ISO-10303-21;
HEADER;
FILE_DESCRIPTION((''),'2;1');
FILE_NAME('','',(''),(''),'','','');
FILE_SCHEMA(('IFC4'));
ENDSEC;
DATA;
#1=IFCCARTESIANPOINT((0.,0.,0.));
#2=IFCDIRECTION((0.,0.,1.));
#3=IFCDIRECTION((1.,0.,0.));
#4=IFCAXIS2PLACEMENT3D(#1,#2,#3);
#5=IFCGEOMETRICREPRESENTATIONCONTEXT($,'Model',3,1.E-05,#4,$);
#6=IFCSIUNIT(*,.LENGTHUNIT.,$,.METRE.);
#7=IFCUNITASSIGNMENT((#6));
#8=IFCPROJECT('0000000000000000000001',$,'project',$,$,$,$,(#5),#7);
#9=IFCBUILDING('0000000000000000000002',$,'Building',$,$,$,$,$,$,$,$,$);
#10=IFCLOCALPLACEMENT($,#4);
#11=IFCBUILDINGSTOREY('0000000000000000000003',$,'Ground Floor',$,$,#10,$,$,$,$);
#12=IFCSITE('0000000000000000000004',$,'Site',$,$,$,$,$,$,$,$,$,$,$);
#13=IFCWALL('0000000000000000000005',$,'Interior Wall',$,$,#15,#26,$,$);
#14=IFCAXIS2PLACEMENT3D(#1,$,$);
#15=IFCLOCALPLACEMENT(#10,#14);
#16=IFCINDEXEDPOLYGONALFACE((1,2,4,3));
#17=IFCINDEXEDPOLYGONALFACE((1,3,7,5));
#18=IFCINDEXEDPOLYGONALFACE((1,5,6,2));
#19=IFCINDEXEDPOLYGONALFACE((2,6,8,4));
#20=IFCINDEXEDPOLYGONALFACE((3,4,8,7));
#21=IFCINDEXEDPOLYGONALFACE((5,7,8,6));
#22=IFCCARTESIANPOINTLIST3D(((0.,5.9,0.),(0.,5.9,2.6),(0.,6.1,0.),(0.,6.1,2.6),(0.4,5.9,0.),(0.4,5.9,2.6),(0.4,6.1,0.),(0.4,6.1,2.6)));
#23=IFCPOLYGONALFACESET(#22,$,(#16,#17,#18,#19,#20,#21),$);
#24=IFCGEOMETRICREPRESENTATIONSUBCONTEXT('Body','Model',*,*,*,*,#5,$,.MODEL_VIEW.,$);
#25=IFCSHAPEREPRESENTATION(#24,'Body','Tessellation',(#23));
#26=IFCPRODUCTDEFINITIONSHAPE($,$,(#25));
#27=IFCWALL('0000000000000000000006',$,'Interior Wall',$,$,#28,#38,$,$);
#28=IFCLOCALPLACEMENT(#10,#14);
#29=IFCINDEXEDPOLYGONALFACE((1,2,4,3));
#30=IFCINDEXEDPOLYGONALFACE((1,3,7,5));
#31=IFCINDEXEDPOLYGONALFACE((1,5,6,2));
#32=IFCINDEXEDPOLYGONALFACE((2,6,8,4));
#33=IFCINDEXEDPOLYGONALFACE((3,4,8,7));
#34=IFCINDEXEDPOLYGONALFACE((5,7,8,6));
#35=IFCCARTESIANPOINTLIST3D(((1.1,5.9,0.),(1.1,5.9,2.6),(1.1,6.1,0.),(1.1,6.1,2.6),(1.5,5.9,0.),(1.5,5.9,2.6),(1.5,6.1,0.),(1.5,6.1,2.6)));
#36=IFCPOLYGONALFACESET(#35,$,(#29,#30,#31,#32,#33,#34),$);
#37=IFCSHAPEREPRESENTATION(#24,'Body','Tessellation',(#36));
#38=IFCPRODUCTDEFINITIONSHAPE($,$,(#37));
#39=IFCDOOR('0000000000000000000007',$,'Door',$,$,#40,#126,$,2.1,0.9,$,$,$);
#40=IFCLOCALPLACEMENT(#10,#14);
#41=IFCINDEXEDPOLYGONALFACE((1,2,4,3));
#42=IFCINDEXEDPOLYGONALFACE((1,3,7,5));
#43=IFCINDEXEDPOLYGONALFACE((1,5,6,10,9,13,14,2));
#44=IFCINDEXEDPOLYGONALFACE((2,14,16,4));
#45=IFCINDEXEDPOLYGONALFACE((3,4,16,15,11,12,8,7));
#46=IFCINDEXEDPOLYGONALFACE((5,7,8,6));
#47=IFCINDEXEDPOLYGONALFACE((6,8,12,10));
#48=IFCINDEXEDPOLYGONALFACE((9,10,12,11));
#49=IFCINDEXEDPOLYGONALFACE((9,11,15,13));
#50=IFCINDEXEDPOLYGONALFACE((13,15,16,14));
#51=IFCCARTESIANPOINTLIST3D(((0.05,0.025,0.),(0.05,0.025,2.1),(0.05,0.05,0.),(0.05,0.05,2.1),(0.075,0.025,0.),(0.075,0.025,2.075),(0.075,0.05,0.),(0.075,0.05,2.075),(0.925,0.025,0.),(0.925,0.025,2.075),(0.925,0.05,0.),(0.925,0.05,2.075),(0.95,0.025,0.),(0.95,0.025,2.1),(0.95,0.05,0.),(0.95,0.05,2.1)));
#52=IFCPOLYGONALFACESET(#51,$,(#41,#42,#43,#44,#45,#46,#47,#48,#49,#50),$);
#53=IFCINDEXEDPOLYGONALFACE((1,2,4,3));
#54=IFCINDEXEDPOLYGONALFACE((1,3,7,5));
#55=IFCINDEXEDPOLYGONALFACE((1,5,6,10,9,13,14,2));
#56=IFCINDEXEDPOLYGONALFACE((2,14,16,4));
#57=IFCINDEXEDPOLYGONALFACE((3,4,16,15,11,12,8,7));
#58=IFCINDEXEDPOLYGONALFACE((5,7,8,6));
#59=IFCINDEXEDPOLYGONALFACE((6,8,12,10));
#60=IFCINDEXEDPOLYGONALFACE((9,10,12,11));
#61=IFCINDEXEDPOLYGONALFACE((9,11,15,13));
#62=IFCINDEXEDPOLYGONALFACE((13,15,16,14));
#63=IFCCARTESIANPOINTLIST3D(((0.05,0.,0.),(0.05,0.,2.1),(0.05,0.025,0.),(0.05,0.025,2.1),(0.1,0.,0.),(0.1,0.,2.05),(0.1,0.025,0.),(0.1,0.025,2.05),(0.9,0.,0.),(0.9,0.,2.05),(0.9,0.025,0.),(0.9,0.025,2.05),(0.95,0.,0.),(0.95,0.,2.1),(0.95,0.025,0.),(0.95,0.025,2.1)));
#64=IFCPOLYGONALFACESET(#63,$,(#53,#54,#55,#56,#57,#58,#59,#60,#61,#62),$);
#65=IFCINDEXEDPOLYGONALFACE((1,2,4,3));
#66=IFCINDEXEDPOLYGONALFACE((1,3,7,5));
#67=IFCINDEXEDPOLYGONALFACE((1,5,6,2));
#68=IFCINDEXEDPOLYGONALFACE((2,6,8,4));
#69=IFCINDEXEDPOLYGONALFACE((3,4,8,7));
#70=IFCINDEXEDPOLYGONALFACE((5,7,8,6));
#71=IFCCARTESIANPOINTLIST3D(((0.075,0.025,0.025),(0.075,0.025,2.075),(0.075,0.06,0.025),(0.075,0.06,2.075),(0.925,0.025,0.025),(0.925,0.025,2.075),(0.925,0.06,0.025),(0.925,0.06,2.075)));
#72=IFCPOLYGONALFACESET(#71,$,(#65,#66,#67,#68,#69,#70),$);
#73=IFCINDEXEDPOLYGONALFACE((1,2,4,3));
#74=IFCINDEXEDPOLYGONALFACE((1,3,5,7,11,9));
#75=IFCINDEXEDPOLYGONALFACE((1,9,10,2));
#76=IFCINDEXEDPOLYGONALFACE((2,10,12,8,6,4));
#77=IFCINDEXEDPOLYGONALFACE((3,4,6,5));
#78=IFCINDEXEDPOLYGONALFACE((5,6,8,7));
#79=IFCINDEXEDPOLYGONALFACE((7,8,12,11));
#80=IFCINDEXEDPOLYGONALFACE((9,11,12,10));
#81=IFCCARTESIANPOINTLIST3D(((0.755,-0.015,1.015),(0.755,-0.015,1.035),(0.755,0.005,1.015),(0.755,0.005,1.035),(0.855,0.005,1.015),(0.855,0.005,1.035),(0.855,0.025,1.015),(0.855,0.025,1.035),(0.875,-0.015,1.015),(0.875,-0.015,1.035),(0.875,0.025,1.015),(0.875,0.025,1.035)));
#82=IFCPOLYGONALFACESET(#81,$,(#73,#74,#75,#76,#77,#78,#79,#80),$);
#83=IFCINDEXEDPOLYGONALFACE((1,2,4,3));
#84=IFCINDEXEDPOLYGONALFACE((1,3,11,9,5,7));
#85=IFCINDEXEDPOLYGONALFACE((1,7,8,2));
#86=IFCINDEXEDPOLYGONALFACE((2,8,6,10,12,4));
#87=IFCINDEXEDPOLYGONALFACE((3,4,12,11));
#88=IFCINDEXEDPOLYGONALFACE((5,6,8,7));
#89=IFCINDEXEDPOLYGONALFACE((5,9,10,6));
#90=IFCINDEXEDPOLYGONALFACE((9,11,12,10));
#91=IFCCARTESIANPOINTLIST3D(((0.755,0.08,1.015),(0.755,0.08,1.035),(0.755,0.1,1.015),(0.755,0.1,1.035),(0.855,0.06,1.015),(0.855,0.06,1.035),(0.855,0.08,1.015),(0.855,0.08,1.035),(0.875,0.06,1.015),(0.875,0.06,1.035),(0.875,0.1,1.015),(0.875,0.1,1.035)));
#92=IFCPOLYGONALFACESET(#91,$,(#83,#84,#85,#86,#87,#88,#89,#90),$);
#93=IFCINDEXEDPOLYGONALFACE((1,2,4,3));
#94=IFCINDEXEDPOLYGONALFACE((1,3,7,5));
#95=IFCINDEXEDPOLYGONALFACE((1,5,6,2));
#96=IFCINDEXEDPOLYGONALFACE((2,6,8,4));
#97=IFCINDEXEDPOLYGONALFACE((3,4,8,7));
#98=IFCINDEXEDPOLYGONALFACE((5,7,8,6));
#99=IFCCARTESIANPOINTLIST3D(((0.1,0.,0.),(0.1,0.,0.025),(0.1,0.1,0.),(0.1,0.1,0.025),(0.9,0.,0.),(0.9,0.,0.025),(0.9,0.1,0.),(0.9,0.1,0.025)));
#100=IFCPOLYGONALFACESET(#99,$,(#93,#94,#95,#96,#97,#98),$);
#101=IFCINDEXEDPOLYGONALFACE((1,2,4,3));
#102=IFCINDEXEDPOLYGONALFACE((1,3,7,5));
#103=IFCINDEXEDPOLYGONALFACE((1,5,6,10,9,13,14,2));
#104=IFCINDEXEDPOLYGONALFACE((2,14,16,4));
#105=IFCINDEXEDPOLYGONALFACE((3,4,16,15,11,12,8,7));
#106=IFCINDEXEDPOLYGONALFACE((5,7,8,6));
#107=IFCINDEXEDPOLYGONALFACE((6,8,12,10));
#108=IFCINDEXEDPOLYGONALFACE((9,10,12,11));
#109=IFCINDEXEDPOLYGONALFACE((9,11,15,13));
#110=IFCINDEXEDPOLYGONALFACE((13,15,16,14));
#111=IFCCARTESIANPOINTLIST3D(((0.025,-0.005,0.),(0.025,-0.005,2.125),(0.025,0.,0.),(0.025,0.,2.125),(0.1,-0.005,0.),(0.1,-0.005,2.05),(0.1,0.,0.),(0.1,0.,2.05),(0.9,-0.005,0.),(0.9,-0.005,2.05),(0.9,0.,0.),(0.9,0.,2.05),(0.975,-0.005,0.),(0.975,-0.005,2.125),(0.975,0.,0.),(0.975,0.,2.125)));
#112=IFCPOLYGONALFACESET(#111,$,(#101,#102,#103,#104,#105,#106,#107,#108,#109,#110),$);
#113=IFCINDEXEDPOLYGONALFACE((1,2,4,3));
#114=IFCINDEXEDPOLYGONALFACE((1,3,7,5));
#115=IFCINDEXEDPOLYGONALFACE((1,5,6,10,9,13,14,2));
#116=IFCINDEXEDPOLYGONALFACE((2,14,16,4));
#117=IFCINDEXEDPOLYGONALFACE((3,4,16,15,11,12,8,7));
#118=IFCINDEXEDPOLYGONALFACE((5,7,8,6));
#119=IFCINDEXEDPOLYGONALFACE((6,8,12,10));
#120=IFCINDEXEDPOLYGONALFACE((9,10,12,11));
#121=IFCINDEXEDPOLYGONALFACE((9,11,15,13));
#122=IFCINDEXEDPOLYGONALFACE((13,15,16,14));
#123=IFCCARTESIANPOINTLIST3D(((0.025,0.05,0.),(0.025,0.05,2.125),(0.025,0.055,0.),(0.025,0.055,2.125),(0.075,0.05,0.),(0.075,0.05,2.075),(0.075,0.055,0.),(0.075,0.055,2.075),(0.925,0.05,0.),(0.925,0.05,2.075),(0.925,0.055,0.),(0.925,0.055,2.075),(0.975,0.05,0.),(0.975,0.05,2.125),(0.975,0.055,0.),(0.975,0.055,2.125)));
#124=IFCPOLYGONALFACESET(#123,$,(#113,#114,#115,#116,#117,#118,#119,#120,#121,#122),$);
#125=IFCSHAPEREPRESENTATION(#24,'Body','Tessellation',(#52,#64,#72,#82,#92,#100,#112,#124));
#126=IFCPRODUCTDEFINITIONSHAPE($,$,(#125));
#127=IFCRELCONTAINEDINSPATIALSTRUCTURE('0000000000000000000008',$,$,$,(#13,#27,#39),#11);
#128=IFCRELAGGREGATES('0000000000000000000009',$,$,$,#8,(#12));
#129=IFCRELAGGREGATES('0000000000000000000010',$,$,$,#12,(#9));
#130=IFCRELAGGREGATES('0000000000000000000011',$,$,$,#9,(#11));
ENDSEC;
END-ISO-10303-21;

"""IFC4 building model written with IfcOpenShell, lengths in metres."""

from ifc_helpers import new_model, si_unit, frame, origin_with_axes, place, context, subcontext, project, spatial, line, indexed_curve, outline, extrude, element, save


model = new_model("IFC4")

# Units and contexts
model_context = context("Model", 3, precision=1e-05, world=origin_with_axes())
body_context = subcontext(model_context, "Body", "Model", "MODEL_VIEW")
ifc_project = project(units=[si_unit("LENGTHUNIT", "METRE")], contexts=[model_context])

# Site, building, storey
site = spatial("IfcSite", under=ifc_project, Name="Site")
building = spatial("IfcBuilding", under=site, Name="Building")
storey_placement = place(None, origin_with_axes())
storey = spatial("IfcBuildingStorey", under=building, at=storey_placement, Name="Ground Floor")

# Walls
wall_1_placement = place(storey_placement, frame((0.0, 6.0, 0.0), z_axis=(0.0, 0.0, 1.0), x_axis=(1.0, 0.0, 0.0)))
element("IfcWall", 1, at=wall_1_placement, inside=storey, Name="Interior Wall", context=body_context, shape_type="SweptSolid", body=[
    extrude(outline(indexed_curve([(0.0, 0.0), (0.0, 0.2), (0.4, 0.2), (0.4, 0.0), (0.0, 0.0)], self_intersect=False)), frame((0.0, -0.1, 0.0), z_axis=(0.0, 0.0, 1.0), x_axis=(1.0, 0.0, 0.0)), (0.0, 0.0, 1.0), 2.6),
])
wall_2_placement = place(storey_placement, frame((1.1, 6.0, 0.0), z_axis=(0.0, 0.0, 1.0), x_axis=(1.0, 0.0, 0.0)))
element("IfcWall", 2, at=wall_2_placement, inside=storey, Name="Interior Wall", context=body_context, shape_type="SweptSolid", body=[
    extrude(outline(indexed_curve([(0.0, 0.0), (0.0, 0.2), (0.4, 0.2), (0.4, 0.0), (0.0, 0.0)], self_intersect=False)), frame((0.0, -0.1, 0.0), z_axis=(0.0, 0.0, 1.0), x_axis=(1.0, 0.0, 0.0)), (0.0, 0.0, 1.0), 2.6),
])

# Door
door_1_placement = place(storey_placement, frame((0.05, 0.0, 0.0), z_axis=(0.0, 0.0, 1.0), x_axis=(1.0, 0.0, 0.0)))
element("IfcDoor", 3, at=door_1_placement, inside=storey, Name="Door", OverallHeight=2.1, OverallWidth=0.9, context=body_context, shape_type="SweptSolid", body=[
    extrude(outline(indexed_curve([(0.0, 0.0), (0.0, 2.1), (0.9, 2.1), (0.9, 0.0), (0.875, 0.0), (0.875, 2.075), (0.025, 2.075), (0.025, 0.0)], segments=[line(1, 2, 3, 4, 5, 6, 7, 8, 1)])), frame((0.0, 0.025, 0.0), z_axis=(0.0, -1.0, 0.0), x_axis=(1.0, 0.0, 0.0)), (0.0, 0.0, -1.0), 0.025),
    extrude(outline(indexed_curve([(0.0, 0.0), (0.0, 2.1), (0.9, 2.1), (0.9, 0.0), (0.85, 0.0), (0.85, 2.05), (0.05, 2.05), (0.05, 0.0)], segments=[line(1, 2, 3, 4, 5, 6, 7, 8, 1)])), frame((0.0, 0.0, 0.0), z_axis=(0.0, -1.0, 0.0), x_axis=(1.0, 0.0, 0.0)), (0.0, 0.0, -1.0), 0.025),
    extrude(outline(indexed_curve([(0.0, 0.0), (0.85, 0.0), (0.85, 0.035), (0.0, 0.035)], segments=[line(1, 2, 3, 4, 1)])), frame((0.025, 0.025, 0.025), z_axis=(0.0, 0.0, 1.0), x_axis=(1.0, 0.0, 0.0)), (0.0, 0.0, 1.0), 2.05),
    extrude(outline(indexed_curve([(0.0, 0.0), (0.0, -0.04), (-0.12, -0.04), (-0.12, -0.02), (-0.02, -0.02), (-0.02, 0.0)], segments=[line(1, 2, 3, 4, 5, 6, 1)])), frame((0.825, 0.025, 1.015), z_axis=(0.0, 0.0, 1.0), x_axis=(1.0, 0.0, 0.0)), (0.0, 0.0, 1.0), 0.02),
    extrude(outline(indexed_curve([(0.0, 0.0), (0.0, 0.04), (-0.12, 0.04), (-0.12, 0.02), (-0.02, 0.02), (-0.02, 0.0)], segments=[line(1, 2, 3, 4, 5, 6, 1)])), frame((0.825, 0.06, 1.015), z_axis=(0.0, 0.0, 1.0), x_axis=(1.0, 0.0, 0.0)), (0.0, 0.0, 1.0), 0.02),
    extrude(outline(indexed_curve([(0.0, 0.0), (0.8, 0.0), (0.8, 0.1), (0.0, 0.1)], segments=[line(1, 2, 3, 4, 1)])), frame((0.05, 0.0, 0.0), z_axis=(0.0, 0.0, 1.0), x_axis=(1.0, 0.0, 0.0)), (0.0, 0.0, 1.0), 0.025),
    extrude(outline(indexed_curve([(0.0, 0.0), (0.0, 2.125), (0.95, 2.125), (0.95, 0.0), (0.875, 0.0), (0.875, 2.05), (0.075, 2.05), (0.075, 0.0)], segments=[line(1, 2, 3, 4, 5, 6, 7, 8, 1)])), frame((-0.025, -0.005, 0.0), z_axis=(0.0, -1.0, 0.0), x_axis=(1.0, 0.0, 0.0)), (0.0, 0.0, -1.0), 0.005),
    extrude(outline(indexed_curve([(0.0, 0.0), (0.0, 2.125), (0.95, 2.125), (0.95, 0.0), (0.9, 0.0), (0.9, 2.075), (0.05, 2.075), (0.05, 0.0)], segments=[line(1, 2, 3, 4, 5, 6, 7, 8, 1)])), frame((-0.025, 0.05, 0.0), z_axis=(0.0, -1.0, 0.0), x_axis=(1.0, 0.0, 0.0)), (0.0, 0.0, -1.0), 0.005),
])

save(model, "model.ifc")
